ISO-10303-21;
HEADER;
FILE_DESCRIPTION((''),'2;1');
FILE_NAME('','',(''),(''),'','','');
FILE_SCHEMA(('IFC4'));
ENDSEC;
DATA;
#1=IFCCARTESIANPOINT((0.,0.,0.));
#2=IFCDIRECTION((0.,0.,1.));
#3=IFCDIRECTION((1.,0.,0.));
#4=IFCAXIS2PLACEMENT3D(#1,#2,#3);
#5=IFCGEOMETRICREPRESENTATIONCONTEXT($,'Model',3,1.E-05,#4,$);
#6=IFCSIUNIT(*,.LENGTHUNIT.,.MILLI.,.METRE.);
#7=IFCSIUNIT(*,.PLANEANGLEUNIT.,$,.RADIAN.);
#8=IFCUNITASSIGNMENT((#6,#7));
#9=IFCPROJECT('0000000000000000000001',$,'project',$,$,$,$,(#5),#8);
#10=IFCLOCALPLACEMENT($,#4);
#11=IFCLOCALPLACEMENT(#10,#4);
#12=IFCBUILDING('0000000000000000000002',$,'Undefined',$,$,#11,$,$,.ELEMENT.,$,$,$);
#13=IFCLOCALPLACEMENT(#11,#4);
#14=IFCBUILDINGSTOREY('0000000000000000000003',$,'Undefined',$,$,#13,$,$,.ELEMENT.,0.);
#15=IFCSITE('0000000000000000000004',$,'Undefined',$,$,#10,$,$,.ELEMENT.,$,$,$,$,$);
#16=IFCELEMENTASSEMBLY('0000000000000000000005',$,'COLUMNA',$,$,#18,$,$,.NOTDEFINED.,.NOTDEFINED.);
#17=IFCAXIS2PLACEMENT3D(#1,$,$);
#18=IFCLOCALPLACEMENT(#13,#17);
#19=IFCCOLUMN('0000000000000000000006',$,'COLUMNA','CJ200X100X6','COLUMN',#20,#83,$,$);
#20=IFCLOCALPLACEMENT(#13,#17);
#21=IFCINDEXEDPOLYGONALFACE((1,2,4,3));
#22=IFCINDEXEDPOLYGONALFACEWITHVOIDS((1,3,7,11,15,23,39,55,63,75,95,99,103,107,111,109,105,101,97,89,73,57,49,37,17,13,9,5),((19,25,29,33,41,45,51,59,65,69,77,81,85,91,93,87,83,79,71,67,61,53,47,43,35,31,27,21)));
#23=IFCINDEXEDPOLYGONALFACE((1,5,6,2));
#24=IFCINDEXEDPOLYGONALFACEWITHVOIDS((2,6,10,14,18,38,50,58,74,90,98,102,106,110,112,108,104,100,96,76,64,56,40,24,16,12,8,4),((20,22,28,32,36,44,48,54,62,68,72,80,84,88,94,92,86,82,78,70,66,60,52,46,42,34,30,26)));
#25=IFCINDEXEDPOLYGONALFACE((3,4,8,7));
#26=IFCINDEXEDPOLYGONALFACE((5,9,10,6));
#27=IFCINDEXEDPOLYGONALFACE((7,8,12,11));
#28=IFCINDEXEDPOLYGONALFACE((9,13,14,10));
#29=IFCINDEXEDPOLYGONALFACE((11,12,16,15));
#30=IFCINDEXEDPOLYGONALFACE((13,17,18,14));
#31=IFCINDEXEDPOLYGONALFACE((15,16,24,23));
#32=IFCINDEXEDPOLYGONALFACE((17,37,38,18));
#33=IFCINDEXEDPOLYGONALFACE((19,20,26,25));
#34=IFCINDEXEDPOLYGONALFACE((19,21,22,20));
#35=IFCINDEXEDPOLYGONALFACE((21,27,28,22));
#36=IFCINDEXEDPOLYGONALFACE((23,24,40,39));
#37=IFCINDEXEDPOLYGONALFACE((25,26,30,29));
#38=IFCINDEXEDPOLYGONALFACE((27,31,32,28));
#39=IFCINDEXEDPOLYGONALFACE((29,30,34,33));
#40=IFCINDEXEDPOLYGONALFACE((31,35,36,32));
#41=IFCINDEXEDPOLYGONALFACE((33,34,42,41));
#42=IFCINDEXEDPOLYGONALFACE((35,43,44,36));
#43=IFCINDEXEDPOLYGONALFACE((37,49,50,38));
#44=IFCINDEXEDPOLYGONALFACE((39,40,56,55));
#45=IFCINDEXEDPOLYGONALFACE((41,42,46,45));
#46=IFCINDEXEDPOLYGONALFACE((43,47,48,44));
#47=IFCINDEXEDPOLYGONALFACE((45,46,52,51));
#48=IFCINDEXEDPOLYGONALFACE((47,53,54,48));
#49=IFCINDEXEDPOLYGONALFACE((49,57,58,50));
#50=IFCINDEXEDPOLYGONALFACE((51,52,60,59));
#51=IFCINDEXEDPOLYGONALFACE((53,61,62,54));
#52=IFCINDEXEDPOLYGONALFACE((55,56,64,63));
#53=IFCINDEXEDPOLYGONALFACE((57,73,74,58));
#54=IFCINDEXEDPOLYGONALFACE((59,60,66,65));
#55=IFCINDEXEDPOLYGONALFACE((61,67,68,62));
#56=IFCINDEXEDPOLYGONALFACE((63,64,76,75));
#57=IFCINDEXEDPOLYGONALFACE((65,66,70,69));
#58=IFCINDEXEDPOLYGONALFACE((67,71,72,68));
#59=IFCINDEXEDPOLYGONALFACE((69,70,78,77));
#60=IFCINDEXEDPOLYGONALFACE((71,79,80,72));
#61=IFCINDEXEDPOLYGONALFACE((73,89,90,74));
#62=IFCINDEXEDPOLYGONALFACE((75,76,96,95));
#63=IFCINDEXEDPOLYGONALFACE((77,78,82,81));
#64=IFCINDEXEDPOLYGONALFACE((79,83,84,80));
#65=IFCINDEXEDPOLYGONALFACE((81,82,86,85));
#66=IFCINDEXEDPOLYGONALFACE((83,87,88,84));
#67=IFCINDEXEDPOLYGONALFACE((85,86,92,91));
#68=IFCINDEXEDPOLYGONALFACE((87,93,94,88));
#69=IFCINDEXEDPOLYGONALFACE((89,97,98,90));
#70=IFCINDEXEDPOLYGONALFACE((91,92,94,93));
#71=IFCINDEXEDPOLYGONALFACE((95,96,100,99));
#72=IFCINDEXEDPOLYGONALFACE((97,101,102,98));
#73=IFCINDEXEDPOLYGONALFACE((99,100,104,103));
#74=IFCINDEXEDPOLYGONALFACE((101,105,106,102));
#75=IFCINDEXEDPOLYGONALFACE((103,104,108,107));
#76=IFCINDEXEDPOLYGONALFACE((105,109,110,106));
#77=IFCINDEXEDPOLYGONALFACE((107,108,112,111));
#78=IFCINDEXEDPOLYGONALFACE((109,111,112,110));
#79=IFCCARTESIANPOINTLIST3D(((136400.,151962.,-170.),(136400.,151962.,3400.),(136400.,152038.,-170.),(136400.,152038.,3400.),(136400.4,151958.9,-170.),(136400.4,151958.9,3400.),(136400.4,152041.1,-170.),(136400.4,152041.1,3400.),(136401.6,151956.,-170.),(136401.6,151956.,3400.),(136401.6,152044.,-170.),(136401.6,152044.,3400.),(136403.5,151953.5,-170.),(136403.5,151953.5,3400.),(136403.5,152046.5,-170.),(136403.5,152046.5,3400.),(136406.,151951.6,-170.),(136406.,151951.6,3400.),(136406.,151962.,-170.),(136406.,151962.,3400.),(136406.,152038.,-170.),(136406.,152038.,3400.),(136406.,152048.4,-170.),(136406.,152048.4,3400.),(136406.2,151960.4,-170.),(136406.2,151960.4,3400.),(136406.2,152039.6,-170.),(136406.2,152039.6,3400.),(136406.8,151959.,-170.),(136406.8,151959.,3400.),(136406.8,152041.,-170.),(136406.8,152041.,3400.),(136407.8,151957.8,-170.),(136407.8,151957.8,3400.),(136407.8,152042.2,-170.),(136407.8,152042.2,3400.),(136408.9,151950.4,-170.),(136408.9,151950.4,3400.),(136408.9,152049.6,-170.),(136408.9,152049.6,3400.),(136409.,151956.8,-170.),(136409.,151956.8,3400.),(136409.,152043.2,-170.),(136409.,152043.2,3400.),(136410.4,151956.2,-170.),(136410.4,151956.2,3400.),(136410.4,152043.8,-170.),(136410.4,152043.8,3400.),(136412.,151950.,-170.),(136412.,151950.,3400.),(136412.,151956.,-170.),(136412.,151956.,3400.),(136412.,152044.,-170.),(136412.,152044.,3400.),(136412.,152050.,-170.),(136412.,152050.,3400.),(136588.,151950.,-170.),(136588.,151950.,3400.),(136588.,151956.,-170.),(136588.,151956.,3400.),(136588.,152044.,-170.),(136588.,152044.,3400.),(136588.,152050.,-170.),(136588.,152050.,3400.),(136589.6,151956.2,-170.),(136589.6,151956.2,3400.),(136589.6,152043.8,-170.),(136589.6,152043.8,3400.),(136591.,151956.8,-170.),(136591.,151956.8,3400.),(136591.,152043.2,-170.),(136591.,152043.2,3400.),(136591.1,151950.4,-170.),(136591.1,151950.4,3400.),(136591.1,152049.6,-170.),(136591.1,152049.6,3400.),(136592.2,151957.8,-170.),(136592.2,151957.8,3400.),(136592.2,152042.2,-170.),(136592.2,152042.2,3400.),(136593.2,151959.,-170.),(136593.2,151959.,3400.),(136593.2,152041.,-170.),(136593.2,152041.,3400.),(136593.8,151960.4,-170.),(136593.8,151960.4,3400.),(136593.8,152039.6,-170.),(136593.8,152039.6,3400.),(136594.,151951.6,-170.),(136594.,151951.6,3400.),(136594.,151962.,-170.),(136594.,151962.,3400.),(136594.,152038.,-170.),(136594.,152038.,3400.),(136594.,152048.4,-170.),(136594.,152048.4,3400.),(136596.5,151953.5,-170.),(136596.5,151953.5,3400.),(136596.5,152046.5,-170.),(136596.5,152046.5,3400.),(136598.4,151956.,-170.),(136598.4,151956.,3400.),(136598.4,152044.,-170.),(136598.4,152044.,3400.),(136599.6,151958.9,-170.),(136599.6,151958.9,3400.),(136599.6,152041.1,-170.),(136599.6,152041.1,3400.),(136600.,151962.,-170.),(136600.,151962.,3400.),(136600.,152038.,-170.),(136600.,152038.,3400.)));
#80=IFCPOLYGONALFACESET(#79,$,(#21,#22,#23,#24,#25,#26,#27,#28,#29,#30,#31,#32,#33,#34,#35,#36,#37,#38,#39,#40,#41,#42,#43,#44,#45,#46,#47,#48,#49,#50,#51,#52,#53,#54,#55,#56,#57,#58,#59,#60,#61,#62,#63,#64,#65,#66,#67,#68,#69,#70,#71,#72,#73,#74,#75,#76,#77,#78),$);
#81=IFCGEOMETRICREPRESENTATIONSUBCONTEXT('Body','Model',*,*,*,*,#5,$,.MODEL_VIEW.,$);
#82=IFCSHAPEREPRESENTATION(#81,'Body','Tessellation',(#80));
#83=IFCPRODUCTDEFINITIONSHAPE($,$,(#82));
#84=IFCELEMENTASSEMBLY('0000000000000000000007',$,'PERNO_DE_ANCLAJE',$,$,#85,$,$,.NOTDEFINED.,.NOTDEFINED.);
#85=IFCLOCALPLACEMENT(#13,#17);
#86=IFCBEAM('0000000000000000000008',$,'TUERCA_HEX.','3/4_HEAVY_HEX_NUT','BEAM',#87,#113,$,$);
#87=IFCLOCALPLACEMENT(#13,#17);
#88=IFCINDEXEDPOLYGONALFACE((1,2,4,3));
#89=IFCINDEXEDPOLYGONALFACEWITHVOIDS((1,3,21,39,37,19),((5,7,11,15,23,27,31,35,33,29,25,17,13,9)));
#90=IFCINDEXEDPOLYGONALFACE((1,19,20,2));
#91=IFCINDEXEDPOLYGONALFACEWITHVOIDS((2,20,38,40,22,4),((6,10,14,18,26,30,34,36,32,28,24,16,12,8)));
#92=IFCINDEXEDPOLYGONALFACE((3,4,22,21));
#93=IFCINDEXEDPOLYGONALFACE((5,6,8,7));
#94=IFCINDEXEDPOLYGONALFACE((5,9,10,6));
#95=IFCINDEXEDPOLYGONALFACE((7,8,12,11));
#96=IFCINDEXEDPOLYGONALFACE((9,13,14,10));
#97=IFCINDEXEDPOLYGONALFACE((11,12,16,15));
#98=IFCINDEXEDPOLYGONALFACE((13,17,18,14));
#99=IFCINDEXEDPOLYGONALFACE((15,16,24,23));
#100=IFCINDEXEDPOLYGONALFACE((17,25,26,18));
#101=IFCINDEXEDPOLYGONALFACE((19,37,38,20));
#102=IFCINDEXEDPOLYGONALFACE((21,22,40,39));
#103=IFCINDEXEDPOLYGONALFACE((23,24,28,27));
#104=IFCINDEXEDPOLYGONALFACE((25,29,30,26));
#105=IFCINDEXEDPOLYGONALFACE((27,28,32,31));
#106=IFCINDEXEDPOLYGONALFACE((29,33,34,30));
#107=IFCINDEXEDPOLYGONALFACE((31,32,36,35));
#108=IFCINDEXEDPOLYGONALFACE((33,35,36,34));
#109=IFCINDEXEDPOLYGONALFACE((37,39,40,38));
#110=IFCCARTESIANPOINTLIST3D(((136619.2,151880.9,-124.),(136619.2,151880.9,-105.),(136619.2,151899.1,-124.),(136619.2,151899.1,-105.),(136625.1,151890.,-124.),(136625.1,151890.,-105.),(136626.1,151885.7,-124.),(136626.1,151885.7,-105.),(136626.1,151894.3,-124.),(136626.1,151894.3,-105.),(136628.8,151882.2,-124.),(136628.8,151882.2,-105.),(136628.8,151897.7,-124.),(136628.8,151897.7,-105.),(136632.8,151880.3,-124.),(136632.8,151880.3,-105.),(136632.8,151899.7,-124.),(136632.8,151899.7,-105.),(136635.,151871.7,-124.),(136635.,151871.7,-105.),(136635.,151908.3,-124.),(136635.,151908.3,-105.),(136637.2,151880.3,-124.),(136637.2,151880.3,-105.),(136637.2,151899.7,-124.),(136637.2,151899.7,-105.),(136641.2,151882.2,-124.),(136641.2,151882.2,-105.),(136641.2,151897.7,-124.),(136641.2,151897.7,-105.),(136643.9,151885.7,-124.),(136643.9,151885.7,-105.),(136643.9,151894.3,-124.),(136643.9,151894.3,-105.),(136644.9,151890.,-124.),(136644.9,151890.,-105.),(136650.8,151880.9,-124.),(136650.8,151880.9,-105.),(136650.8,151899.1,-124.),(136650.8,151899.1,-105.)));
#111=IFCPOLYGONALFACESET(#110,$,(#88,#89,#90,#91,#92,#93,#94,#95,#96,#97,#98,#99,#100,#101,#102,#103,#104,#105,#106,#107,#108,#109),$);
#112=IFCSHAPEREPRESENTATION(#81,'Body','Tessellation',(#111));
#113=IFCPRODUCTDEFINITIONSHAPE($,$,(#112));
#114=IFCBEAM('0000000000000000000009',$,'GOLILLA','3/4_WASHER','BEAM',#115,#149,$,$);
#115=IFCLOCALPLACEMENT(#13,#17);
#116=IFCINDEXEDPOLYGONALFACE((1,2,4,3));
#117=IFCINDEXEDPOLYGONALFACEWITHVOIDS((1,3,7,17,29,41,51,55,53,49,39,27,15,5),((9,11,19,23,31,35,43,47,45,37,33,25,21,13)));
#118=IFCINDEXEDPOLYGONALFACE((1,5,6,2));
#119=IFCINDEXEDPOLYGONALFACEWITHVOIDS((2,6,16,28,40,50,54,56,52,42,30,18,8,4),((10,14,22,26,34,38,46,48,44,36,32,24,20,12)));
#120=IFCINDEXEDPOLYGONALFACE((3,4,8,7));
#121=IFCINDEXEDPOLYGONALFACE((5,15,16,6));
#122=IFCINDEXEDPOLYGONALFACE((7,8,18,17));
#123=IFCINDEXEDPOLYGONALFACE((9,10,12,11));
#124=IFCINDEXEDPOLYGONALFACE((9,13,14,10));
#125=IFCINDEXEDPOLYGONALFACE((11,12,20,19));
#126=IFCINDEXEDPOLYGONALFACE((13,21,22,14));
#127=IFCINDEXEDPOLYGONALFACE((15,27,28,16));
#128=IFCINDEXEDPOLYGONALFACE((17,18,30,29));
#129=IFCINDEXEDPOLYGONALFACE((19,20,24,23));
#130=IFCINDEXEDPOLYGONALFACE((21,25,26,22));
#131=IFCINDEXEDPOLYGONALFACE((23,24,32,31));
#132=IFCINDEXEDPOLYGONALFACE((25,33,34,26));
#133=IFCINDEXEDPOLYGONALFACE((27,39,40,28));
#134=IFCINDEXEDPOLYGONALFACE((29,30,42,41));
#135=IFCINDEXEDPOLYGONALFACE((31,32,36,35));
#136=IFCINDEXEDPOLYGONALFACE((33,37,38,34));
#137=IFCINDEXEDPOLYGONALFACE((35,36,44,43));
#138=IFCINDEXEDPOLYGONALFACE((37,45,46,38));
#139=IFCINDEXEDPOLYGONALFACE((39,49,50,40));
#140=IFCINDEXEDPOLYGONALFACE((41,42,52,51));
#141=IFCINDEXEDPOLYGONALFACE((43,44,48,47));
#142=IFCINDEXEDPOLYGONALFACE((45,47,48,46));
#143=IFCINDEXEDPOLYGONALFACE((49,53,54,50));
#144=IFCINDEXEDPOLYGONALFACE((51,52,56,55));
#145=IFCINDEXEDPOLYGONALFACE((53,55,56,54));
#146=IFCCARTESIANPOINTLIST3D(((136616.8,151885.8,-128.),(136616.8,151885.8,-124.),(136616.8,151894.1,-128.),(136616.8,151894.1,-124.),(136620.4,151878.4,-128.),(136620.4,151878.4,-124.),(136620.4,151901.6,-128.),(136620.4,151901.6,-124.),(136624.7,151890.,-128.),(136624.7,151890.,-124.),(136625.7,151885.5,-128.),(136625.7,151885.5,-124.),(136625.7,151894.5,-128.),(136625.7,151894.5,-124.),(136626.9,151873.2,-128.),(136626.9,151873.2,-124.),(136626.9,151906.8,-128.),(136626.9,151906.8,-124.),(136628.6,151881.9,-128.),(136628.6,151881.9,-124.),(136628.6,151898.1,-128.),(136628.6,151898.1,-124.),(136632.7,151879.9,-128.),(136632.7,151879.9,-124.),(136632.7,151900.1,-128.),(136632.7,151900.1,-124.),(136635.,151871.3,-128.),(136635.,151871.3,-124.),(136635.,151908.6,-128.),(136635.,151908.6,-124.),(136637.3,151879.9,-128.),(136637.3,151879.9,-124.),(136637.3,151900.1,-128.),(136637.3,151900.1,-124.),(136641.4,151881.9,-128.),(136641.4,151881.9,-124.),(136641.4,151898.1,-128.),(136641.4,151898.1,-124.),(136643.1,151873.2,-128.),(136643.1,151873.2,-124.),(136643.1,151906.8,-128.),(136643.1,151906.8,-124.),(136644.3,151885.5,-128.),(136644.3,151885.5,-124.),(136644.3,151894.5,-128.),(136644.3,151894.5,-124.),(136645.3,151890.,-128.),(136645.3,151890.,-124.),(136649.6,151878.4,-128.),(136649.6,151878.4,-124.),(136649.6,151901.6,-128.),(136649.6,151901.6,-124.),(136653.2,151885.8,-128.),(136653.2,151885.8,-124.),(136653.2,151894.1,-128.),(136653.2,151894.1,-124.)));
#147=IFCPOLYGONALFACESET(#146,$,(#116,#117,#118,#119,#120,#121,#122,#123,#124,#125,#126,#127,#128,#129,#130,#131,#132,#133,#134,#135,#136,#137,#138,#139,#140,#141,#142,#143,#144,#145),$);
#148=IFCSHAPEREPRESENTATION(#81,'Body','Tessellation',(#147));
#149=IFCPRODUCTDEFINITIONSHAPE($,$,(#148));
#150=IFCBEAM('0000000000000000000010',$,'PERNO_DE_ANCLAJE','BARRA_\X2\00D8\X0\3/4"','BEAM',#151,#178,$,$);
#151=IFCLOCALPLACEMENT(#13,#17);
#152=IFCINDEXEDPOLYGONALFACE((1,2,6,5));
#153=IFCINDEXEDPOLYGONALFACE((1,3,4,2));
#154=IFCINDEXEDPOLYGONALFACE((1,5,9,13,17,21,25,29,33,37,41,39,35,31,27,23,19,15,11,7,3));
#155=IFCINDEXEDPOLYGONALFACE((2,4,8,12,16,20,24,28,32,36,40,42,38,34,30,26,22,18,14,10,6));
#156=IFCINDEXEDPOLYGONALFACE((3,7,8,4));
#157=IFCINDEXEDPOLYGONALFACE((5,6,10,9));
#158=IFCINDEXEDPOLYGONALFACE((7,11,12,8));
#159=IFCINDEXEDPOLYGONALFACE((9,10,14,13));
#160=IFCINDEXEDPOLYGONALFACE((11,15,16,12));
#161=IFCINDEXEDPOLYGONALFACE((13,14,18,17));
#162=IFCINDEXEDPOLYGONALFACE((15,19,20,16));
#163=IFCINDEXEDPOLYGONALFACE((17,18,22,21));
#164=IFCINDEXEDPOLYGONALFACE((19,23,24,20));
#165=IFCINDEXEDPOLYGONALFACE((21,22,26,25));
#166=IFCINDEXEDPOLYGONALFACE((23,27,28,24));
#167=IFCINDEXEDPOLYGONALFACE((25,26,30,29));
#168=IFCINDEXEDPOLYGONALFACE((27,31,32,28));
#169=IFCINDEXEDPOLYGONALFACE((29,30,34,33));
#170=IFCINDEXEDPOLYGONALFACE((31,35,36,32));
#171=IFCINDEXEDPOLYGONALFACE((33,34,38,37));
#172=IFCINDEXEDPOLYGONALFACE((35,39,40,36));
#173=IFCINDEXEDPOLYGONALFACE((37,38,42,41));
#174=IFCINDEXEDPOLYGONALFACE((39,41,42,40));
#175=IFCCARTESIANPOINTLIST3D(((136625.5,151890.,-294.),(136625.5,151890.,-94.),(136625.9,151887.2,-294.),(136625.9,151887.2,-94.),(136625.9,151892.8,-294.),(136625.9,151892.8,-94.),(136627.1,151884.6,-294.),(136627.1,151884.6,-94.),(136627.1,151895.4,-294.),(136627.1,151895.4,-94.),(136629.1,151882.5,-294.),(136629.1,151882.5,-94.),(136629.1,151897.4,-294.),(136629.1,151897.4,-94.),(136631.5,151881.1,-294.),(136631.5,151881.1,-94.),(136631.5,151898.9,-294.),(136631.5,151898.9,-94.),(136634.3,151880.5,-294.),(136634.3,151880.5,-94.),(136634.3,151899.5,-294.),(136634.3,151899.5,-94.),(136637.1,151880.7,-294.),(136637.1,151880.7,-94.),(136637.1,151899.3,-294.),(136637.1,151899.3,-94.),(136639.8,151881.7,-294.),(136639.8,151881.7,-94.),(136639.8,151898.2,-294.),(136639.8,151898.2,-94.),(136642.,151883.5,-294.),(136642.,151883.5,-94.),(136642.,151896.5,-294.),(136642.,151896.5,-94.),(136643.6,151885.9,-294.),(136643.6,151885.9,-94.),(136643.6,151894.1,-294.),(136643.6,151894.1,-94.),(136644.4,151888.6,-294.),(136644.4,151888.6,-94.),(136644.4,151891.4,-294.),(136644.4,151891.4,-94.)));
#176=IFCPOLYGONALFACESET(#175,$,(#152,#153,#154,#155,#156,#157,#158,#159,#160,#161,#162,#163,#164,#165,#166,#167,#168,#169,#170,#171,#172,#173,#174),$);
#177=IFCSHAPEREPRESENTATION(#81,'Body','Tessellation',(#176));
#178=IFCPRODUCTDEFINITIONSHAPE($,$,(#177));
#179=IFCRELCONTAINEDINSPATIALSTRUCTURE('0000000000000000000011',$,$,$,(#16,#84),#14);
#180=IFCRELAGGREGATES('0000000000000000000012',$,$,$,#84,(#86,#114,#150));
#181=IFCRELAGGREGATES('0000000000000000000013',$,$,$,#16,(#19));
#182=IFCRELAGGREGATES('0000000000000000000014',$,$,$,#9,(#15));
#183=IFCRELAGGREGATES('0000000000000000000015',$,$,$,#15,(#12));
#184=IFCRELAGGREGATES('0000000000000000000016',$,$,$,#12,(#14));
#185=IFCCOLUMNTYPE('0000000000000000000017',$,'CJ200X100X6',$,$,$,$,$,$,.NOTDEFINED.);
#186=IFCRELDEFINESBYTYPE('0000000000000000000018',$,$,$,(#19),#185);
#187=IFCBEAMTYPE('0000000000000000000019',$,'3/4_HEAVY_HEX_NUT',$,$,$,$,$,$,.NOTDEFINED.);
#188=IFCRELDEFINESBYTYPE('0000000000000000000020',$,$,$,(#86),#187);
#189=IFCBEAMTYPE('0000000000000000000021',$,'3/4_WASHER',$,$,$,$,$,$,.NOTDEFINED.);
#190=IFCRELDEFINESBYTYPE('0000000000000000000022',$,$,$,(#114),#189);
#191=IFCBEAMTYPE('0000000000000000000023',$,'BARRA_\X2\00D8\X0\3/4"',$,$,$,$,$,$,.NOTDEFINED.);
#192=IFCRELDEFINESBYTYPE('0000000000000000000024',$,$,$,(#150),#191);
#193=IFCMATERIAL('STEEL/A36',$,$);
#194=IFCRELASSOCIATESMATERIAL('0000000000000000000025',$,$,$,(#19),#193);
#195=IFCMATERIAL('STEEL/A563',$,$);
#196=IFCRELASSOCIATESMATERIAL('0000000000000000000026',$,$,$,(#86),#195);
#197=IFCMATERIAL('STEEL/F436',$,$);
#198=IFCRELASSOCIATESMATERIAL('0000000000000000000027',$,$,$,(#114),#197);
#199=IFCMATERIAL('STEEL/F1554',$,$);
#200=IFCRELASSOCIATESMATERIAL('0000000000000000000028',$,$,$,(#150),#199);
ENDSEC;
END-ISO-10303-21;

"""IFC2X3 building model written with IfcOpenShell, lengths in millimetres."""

from ifc_helpers import new_model, si_unit, frame, origin_with_axes, origin_2d_with_axis, place, context, subcontext, project, spatial, polyline, hollow_rectangle, circle, outline, extrude, material, type_object, element, aggregate, save


model = new_model("IFC2X3")

# Units and contexts
model_context = context("Model", 3, precision=1e-05, world=origin_with_axes())
body_context = subcontext(model_context, "Body", "Model", "MODEL_VIEW")
ifc_project = project(units=[si_unit("LENGTHUNIT", "METRE", prefix="MILLI"), si_unit("PLANEANGLEUNIT", "RADIAN")], contexts=[model_context])

# Site, building, storey
site_placement = place(None, origin_with_axes())
site = spatial("IfcSite", under=ifc_project, at=site_placement, Name="Undefined", CompositionType="ELEMENT")
building_placement = place(site_placement, origin_with_axes())
building = spatial("IfcBuilding", under=site, at=building_placement, Name="Undefined", CompositionType="ELEMENT")
storey_placement = place(building_placement, origin_with_axes())
storey = spatial("IfcBuildingStorey", under=building, at=storey_placement, Name="Undefined", CompositionType="ELEMENT", Elevation=0.0)

# Element assembly, column
assembly_1_placement = place(storey_placement, origin_with_axes())
assembly_1 = element("IfcElementAssembly", 1, at=assembly_1_placement, inside=storey, Name="COLUMNA", AssemblyPlace="NOTDEFINED", PredefinedType="NOTDEFINED")
ifc_material_1 = material(Name="STEEL/A36")
column_type = type_object("IfcColumnType", Name="CJ200X100X6", PredefinedType="NOTDEFINED")
column_placement = place(assembly_1_placement, frame((136500.0, 152000.0, -170.0), z_axis=(0.0, 0.0, 1.0), x_axis=(-1.0, 0.0, 0.0)))
column = element("IfcColumn", 2, at=column_placement, type_object=column_type, material=ifc_material_1, Name="COLUMNA", Description="CJ200X100X6", ObjectType="COLUMN", context=body_context, shape_type="SweptSolid", body=[
    extrude(hollow_rectangle(XDim=100.0, YDim=200.0, WallThickness=6.0, InnerFilletRadius=6.0, OuterFilletRadius=12.0, at=origin_2d_with_axis()), frame((0.0, 0.0, 3570.0), z_axis=(0.0, 0.0, -1.0), x_axis=(0.0, 1.0, 0.0)), (0.0, 0.0, 1.0), 3570.0),
])

# Element assembly, beams
assembly_2_placement = place(storey_placement, origin_with_axes())
assembly_2 = element("IfcElementAssembly", 3, at=assembly_2_placement, inside=storey, Name="PERNO_DE_ANCLAJE", AssemblyPlace="NOTDEFINED", PredefinedType="NOTDEFINED")
ifc_material_2 = material(Name="STEEL/A563")
beam_type_1 = type_object("IfcBeamType", Name="3/4_HEAVY_HEX_NUT", PredefinedType="NOTDEFINED")
beam_1_placement = place(assembly_2_placement, frame((136635.0, 151890.0, -105.0), z_axis=(1.0, 0.0, 0.0), x_axis=(0.0, 0.0, -1.0)))
beam_1 = element("IfcBeam", 4, at=beam_1_placement, type_object=beam_type_1, material=ifc_material_2, Name="TUERCA_HEX.", Description="3/4_HEAVY_HEX_NUT", ObjectType="BEAM", context=body_context, shape_type="SweptSolid", body=[
    extrude(outline(polyline([(-9.1, -15.8), (-18.3, 0.0), (-9.1, 15.8), (9.1, 15.8), (18.3, 0.0), (9.1, -15.8), (-9.1, -15.8)]), holes=[polyline([(7.8, 6.2), (4.3, 8.9), (0.0, 9.9), (-4.3, 8.9), (-7.8, 6.2), (-9.7, 2.2), (-9.7, -2.2), (-7.8, -6.2), (-4.3, -8.9), (0.0, -9.9), (4.3, -8.9), (7.8, -6.2), (9.7, -2.2), (9.7, 2.2), (7.8, 6.2)])]), frame((19.0, 0.0, 0.0), z_axis=(-1.0, 0.0, 0.0), x_axis=(0.0, -1.0, 0.0)), (0.0, 0.0, 1.0), 19.0),
])
ifc_material_3 = material(Name="STEEL/F436")
beam_type_2 = type_object("IfcBeamType", Name="3/4_WASHER", PredefinedType="NOTDEFINED")
beam_2_placement = place(assembly_2_placement, frame((136635.0, 151890.0, -124.0), z_axis=(1.0, 0.0, 0.0), x_axis=(0.0, 0.0, -1.0)))
beam_2 = element("IfcBeam", 5, at=beam_2_placement, type_object=beam_type_2, material=ifc_material_3, Name="GOLILLA", Description="3/4_WASHER", ObjectType="BEAM", context=body_context, shape_type="SweptSolid", body=[
    extrude(outline(polyline([(-16.8, 8.1), (-11.6, 14.6), (-4.2, 18.2), (4.2, 18.2), (11.6, 14.6), (16.8, 8.1), (18.6, 0.0), (16.8, -8.1), (11.6, -14.6), (4.2, -18.2), (-4.2, -18.2), (-11.6, -14.6), (-16.8, -8.1), (-18.6, 0.0), (-16.8, 8.1)]), holes=[polyline([(8.1, 6.4), (4.5, 9.3), (0.0, 10.3), (-4.5, 9.3), (-8.1, 6.4), (-10.1, 2.3), (-10.1, -2.3), (-8.1, -6.4), (-4.5, -9.3), (0.0, -10.3), (4.5, -9.3), (8.1, -6.4), (10.1, -2.3), (10.1, 2.3), (8.1, 6.4)])]), frame((4.0, 0.0, 0.0), z_axis=(-1.0, 0.0, 0.0), x_axis=(0.0, -1.0, 0.0)), (0.0, 0.0, 1.0), 4.0),
])
ifc_material_4 = material(Name="STEEL/F1554")
beam_type_3 = type_object("IfcBeamType", Name="BARRA_Ø3/4\"", PredefinedType="NOTDEFINED")
beam_3_placement = place(assembly_2_placement, frame((136635.0, 151890.0, -94.0), z_axis=(0.0, -1.0, 0.0), x_axis=(0.0, 0.0, -1.0)))
beam_3 = element("IfcBeam", 6, at=beam_3_placement, type_object=beam_type_3, material=ifc_material_4, Name="PERNO_DE_ANCLAJE", Description="BARRA_Ø3/4\"", ObjectType="BEAM", context=body_context, shape_type="SweptSolid", body=[
    extrude(circle(Radius=9.5, at=origin_2d_with_axis()), frame((200.0, 0.0, 0.0), z_axis=(-1.0, 0.0, 0.0), x_axis=(0.0, -1.0, 0.0)), (0.0, 0.0, 1.0), 200.0),
])
aggregate(assembly_2, [beam_1, beam_2, beam_3])

aggregate(assembly_1, [column])

save(model, "model.ifc")
